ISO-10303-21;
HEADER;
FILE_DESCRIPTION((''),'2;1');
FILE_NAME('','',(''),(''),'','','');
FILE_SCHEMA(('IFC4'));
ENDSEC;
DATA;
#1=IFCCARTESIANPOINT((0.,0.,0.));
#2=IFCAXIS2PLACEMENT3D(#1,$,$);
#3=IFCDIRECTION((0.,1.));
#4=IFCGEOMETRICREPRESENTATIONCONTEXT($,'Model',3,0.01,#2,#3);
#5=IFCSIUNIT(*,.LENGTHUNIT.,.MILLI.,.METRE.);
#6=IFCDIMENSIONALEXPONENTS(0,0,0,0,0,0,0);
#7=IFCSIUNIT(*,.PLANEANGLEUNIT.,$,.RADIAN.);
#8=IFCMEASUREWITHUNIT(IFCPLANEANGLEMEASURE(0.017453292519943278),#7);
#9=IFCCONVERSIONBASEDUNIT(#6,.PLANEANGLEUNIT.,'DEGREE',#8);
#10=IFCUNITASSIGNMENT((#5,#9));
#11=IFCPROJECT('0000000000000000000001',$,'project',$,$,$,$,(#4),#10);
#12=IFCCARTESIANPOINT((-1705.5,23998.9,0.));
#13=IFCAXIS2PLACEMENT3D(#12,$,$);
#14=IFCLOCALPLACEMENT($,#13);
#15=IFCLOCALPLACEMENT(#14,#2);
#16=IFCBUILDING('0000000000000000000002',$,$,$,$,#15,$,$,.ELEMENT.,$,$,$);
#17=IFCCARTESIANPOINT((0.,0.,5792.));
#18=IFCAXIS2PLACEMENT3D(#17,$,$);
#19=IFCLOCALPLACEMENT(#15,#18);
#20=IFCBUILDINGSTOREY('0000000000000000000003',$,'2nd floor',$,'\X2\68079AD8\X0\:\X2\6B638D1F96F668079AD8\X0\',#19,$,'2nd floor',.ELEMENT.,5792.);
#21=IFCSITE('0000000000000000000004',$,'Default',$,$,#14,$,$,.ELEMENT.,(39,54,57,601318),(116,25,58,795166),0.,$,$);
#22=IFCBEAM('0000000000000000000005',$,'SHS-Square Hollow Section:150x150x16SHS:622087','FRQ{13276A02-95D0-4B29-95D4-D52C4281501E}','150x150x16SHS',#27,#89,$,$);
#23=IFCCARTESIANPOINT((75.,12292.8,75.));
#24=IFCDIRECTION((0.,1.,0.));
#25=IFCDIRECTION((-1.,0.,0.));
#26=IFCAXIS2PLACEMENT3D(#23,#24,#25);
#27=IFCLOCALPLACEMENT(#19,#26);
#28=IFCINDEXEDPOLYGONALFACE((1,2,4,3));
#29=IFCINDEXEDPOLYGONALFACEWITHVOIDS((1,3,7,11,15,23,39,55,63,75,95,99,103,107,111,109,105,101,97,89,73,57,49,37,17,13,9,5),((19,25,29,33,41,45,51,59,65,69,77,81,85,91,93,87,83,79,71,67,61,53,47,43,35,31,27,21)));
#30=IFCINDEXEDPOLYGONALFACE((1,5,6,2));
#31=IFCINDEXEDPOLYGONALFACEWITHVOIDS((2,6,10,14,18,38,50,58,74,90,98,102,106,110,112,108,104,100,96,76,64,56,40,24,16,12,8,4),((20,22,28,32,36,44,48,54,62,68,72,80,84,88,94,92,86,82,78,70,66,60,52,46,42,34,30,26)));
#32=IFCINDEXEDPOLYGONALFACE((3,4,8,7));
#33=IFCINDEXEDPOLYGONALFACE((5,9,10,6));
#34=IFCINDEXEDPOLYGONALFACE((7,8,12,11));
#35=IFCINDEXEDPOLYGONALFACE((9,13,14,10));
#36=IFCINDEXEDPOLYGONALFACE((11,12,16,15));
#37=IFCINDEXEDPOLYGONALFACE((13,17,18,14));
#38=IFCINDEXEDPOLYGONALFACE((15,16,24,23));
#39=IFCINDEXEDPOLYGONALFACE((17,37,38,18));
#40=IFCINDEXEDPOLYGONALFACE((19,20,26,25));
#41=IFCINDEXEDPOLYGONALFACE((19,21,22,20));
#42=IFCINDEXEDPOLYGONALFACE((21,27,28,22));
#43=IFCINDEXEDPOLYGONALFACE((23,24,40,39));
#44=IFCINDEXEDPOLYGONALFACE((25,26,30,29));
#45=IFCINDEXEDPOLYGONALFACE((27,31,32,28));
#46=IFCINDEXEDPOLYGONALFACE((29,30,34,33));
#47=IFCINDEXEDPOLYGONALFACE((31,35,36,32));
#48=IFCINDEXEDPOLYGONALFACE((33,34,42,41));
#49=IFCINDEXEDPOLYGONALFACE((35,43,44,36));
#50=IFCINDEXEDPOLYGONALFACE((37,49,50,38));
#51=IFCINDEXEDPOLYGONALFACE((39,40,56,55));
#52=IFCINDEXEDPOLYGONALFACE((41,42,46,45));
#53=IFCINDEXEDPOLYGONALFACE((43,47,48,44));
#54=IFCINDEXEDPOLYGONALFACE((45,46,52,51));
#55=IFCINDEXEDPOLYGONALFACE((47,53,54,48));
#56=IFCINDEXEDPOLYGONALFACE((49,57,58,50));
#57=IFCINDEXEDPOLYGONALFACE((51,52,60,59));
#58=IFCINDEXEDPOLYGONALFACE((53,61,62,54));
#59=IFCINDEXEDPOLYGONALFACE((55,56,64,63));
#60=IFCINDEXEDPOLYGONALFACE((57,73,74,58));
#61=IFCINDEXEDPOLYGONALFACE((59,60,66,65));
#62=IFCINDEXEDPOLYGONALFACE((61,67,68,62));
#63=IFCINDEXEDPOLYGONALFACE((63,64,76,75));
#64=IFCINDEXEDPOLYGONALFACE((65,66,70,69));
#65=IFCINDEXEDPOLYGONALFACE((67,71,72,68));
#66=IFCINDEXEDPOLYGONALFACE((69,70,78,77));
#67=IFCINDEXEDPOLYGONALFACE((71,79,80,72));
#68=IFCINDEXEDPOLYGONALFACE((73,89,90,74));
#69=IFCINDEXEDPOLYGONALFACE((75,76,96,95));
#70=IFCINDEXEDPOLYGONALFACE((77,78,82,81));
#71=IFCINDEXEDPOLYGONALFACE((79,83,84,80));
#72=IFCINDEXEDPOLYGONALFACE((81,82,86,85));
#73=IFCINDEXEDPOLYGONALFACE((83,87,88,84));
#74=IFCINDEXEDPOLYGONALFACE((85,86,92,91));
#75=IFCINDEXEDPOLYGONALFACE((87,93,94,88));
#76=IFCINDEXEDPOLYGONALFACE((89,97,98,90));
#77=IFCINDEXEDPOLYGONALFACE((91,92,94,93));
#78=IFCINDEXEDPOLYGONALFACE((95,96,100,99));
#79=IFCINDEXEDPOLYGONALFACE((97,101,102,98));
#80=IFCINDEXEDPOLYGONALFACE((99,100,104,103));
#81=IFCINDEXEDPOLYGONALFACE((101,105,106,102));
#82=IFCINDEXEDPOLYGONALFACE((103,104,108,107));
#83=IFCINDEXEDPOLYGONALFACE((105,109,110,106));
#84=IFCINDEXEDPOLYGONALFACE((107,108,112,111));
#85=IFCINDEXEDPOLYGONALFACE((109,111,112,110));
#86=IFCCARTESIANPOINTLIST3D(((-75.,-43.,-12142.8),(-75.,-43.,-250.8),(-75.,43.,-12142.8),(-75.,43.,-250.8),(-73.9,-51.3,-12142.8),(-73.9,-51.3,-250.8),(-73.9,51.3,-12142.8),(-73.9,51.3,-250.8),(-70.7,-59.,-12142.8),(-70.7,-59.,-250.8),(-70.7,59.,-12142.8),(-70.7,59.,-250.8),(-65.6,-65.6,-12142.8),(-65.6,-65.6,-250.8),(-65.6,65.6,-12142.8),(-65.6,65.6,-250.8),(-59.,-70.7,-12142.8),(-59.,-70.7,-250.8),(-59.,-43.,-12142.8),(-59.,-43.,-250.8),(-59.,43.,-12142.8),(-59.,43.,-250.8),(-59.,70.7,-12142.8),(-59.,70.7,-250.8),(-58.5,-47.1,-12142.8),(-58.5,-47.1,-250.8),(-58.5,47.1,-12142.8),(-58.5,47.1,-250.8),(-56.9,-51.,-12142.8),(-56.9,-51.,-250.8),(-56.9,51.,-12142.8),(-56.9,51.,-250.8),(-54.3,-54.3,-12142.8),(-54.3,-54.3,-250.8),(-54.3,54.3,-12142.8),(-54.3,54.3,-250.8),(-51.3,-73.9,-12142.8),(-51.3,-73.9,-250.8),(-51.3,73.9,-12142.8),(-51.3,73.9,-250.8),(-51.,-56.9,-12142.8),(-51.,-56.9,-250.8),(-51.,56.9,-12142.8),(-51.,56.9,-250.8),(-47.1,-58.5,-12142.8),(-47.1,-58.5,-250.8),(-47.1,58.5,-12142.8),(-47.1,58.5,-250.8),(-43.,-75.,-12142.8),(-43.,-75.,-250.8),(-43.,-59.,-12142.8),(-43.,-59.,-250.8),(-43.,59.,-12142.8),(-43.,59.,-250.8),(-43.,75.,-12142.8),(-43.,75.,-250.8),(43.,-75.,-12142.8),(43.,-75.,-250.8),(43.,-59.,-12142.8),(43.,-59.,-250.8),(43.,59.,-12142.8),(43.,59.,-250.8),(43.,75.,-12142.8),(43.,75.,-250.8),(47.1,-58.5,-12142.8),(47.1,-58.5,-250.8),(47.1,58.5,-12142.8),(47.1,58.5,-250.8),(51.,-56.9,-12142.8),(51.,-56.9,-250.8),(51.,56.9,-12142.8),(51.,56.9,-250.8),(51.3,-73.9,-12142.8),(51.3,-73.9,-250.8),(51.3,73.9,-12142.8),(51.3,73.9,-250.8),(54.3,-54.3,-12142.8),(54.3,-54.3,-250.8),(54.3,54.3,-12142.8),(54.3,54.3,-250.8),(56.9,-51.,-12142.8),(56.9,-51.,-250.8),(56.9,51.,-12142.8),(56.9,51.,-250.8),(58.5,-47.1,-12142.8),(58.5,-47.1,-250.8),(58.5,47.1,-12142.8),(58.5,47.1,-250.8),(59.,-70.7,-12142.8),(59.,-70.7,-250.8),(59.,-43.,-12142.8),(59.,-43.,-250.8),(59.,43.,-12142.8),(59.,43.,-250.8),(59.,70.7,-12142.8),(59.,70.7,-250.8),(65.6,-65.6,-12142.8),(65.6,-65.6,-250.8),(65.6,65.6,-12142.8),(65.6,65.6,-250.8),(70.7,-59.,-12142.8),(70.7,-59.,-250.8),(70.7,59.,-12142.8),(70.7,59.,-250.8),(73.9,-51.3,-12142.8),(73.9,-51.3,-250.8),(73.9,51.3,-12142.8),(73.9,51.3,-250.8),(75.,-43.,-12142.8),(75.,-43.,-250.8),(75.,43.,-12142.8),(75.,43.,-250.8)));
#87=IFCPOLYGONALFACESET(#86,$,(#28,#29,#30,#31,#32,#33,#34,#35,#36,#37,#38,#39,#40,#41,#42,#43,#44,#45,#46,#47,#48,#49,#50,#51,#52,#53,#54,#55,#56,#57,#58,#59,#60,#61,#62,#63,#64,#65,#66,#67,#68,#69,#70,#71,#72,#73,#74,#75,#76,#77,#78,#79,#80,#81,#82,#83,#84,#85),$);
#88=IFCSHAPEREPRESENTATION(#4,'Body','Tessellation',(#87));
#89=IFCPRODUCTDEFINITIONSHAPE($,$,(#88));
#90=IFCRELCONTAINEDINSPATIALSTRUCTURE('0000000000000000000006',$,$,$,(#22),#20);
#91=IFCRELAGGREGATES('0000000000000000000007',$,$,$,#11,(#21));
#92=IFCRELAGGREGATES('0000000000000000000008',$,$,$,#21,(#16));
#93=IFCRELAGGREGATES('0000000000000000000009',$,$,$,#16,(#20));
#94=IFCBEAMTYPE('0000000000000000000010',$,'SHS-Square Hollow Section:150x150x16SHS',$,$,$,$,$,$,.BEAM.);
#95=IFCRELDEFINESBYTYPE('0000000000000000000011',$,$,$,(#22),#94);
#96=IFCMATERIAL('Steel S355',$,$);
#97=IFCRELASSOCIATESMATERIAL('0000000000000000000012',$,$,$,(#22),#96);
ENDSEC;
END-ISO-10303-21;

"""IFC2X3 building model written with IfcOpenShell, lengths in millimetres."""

from ifc_helpers import new_model, entity, si_unit, converted_unit, direction, frame, origin, origin_2d, place, context, project, spatial, hollow_rectangle, extrude, clip, halfspace, material, type_object, element, save


model = new_model("IFC2X3")

# Units and contexts
model_context = context("Model", 3, precision=0.01, world=origin(), true_north=direction((0.0, 1.0)))
ifc_project = project(units=[si_unit("LENGTHUNIT", "METRE", prefix="MILLI"), converted_unit("PLANEANGLEUNIT", "DEGREE", entity("IfcPlaneAngleMeasure", 0.017453292519943278), si_unit("PLANEANGLEUNIT", "RADIAN"), dimensions=[0, 0, 0, 0, 0, 0, 0])], contexts=[model_context])

# Site, building, storey
site_placement = place(None, frame((-1705.5, 23998.9, 0.0)))
site = spatial("IfcSite", under=ifc_project, at=site_placement, Name="Default", CompositionType="ELEMENT", RefLatitude=(39, 54, 57, 601318), RefLongitude=(116, 25, 58, 795166), RefElevation=0.0)
building_placement = place(site_placement, origin())
building = spatial("IfcBuilding", under=site, at=building_placement, CompositionType="ELEMENT")
storey_placement = place(building_placement, frame((0.0, 0.0, 5792.0)))
storey = spatial("IfcBuildingStorey", under=building, at=storey_placement, Name="2nd floor", ObjectType="标高:正负零标高", LongName="2nd floor", CompositionType="ELEMENT", Elevation=5792.0)

# Shared definitions
ifc_material_1 = material(Name="Steel S355")

# Beam
beam_type_1 = type_object("IfcBeamType", Name="SHS-Square Hollow Section:150x150x16SHS", PredefinedType="BEAM")
beam_1_placement = place(storey_placement, frame((75.0, 12292.8, 75.0), z_axis=(0.0, 1.0, 0.0), x_axis=(-1.0, 0.0, 0.0)))
element("IfcBeam", 1, at=beam_1_placement, inside=storey, type_object=beam_type_1, material=ifc_material_1, Name="SHS-Square Hollow Section:150x150x16SHS:622087", Description="FRQ{13276A02-95D0-4B29-95D4-D52C4281501E}", ObjectType="150x150x16SHS", context=model_context, shape_type="Clipping", body=[
    clip(clip(extrude(hollow_rectangle(XDim=150.0, YDim=150.0, WallThickness=16.0, InnerFilletRadius=16.0, OuterFilletRadius=32.0, at=origin_2d()), origin(), (0.0, 0.0, -1.0), 12398.9), halfspace(frame((75.0, -5867.0, -12142.8), z_axis=(0.0, 0.0, 1.0), x_axis=(1.0, 0.0, 0.0)), True)), halfspace(frame((75.0, -5867.0, -250.8), z_axis=(0.0, 0.0, -1.0), x_axis=(-1.0, 0.0, 0.0)), True)),
])

save(model, "model.ifc")
